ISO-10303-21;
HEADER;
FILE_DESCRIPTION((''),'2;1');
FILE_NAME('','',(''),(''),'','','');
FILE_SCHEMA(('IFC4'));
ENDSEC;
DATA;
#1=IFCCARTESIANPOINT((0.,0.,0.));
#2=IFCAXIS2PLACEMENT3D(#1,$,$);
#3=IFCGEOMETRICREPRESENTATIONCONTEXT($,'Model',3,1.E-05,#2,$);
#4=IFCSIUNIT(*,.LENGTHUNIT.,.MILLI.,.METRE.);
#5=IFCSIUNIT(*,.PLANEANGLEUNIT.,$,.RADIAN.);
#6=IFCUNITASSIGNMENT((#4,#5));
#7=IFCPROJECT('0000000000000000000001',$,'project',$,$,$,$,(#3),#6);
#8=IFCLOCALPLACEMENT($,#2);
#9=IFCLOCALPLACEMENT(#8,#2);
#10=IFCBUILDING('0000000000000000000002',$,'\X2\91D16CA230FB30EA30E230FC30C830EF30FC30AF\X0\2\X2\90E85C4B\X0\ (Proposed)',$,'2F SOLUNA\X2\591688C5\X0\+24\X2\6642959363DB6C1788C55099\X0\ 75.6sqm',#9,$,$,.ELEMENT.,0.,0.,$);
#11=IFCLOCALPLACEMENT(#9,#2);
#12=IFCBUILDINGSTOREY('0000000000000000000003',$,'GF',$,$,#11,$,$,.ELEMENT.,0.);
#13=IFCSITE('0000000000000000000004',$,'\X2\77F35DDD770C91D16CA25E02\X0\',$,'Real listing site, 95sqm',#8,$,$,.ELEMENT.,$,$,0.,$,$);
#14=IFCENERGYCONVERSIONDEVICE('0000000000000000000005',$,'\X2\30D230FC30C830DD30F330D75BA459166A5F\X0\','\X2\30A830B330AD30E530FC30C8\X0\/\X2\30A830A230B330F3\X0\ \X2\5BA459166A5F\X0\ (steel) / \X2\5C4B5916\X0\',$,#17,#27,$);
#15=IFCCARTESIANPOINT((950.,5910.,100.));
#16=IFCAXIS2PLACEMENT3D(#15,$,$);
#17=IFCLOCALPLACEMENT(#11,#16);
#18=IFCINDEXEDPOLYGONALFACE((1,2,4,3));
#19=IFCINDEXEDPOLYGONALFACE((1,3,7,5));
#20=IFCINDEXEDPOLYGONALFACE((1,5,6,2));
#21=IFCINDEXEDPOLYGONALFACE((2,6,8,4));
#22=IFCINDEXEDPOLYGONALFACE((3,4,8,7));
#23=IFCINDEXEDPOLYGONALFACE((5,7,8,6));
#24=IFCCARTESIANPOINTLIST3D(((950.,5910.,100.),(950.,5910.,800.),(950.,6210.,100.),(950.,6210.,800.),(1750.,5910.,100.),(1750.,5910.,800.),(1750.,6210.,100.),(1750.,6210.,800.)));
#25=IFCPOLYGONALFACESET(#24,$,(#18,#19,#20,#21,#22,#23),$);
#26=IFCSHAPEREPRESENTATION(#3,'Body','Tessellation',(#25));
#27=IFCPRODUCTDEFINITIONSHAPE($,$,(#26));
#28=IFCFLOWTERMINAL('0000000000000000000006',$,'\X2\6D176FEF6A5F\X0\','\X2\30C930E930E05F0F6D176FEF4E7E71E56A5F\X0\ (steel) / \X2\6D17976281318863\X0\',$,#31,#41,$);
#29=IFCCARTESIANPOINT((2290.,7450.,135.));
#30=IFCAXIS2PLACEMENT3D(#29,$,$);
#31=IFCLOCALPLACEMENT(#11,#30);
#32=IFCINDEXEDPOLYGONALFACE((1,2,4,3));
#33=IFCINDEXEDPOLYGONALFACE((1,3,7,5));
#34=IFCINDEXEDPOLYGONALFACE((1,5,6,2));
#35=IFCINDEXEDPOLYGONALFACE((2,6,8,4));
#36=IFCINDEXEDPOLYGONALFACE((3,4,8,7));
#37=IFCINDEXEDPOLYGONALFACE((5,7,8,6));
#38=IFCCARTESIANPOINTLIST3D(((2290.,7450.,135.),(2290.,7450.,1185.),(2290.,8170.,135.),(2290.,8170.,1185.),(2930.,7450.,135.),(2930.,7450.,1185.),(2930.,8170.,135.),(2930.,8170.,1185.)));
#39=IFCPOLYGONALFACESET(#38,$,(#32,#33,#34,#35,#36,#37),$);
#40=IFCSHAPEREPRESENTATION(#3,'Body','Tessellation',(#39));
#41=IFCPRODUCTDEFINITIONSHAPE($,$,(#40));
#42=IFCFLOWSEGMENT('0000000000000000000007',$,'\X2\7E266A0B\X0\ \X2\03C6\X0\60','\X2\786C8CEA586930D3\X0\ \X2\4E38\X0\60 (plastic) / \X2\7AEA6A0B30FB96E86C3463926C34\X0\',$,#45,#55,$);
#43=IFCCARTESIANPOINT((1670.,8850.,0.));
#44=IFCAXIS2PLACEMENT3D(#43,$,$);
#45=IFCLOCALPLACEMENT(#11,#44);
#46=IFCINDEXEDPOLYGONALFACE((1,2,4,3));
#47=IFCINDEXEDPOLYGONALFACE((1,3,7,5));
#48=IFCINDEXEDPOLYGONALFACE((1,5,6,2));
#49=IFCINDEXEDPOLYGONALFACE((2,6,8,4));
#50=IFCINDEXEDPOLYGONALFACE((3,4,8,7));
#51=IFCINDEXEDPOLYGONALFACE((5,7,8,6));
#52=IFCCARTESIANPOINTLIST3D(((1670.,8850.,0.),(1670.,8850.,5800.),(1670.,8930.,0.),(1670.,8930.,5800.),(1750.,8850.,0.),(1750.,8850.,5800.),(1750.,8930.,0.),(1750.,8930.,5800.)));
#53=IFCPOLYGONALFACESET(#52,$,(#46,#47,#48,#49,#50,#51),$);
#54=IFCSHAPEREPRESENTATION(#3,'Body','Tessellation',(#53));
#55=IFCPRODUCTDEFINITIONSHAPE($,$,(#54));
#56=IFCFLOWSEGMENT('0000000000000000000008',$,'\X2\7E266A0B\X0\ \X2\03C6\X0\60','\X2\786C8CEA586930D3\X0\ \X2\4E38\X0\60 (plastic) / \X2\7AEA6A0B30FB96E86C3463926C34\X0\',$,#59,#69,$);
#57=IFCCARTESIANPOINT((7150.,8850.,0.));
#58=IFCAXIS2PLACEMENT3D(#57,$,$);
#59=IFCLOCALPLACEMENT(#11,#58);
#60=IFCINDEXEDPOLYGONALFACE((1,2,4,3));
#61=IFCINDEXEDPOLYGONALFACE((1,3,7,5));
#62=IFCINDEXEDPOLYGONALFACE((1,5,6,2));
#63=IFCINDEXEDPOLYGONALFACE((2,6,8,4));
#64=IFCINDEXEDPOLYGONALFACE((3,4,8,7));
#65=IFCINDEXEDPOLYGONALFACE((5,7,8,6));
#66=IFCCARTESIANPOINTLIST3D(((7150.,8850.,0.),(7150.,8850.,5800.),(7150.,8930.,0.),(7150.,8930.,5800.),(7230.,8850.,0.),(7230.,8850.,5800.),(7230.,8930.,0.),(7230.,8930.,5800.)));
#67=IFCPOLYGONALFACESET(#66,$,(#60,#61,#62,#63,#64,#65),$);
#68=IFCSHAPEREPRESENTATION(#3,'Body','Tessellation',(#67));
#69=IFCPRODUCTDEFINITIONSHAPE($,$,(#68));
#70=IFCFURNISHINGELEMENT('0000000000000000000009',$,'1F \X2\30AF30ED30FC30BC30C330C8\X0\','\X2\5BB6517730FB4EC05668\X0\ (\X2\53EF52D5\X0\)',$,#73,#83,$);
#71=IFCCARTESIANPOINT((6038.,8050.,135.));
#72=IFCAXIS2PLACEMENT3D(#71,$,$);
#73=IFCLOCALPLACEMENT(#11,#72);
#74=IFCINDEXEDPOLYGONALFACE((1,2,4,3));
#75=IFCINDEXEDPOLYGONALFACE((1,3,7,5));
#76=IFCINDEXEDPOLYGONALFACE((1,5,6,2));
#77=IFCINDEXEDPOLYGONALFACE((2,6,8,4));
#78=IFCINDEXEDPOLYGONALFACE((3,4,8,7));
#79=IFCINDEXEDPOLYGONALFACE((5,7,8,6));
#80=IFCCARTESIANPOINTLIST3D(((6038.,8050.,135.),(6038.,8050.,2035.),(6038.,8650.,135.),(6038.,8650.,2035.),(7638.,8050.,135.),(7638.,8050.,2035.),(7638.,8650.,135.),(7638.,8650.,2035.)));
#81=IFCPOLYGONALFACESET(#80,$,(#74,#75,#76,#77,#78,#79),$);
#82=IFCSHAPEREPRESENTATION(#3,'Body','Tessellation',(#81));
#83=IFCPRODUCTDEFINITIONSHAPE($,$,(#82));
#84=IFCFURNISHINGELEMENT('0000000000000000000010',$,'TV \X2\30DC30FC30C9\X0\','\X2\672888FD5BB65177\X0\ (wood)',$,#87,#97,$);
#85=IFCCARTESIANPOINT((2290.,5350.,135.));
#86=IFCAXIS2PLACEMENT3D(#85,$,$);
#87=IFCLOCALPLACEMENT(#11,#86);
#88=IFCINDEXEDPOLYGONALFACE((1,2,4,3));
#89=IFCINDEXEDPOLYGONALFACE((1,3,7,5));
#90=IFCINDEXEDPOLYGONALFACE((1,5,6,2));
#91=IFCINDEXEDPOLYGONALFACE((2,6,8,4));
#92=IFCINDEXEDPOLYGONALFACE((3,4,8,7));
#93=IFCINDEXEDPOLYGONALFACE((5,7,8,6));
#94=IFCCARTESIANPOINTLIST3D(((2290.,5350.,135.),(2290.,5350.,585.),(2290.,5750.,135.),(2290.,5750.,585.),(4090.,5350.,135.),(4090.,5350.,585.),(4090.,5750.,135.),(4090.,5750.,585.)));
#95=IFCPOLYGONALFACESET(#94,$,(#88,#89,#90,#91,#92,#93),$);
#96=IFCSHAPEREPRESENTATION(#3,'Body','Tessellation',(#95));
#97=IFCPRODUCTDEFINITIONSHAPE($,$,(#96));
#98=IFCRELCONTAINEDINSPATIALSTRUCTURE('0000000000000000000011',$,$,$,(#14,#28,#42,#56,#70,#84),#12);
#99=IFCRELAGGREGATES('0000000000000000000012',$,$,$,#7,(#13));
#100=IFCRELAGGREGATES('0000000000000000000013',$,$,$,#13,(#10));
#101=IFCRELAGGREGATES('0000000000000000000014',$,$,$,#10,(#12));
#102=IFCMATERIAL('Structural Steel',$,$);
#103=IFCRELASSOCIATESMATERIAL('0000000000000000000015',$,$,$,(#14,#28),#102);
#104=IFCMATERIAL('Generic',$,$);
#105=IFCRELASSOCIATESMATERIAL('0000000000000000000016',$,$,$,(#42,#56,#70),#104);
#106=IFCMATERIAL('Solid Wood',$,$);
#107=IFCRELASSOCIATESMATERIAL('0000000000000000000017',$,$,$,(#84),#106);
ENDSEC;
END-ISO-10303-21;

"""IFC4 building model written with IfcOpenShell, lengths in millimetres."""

from ifc_helpers import new_model, si_unit, frame, frame_2d, origin, place, context, project, spatial, rectangle, extrude, material, element, save


model = new_model("IFC4")

# Units and contexts
model_context = context("Model", 3, precision=1e-05, world=origin())
ifc_project = project(units=[si_unit("LENGTHUNIT", "METRE", prefix="MILLI"), si_unit("PLANEANGLEUNIT", "RADIAN")], contexts=[model_context])

# Site, building, storey
site_placement = place(None, origin())
site = spatial("IfcSite", under=ifc_project, at=site_placement, Name="石川県金沢市", ObjectType="Real listing site, 95sqm", CompositionType="ELEMENT", RefElevation=0.0)
building_placement = place(site_placement, origin())
building = spatial("IfcBuilding", under=site, at=building_placement, Name="金沢・リモートワーク2部屋 (Proposed)", ObjectType="2F SOLUNA外装+24時間換気装備 75.6sqm", CompositionType="ELEMENT", ElevationOfRefHeight=0.0, ElevationOfTerrain=0.0)
storey_placement = place(building_placement, origin())
storey = spatial("IfcBuildingStorey", under=building, at=storey_placement, Name="GF", CompositionType="ELEMENT", Elevation=0.0)

# Shared definitions
ifc_material_1 = material(Name="Solid Wood")

# Shared definitions
ifc_material_2 = material(Name="Generic")

# Shared definitions
ifc_material_3 = material(Name="Structural Steel")

# Energy conversion device
energy_conversion_device_placement = place(storey_placement, frame((950.0, 5910.0, 100.0)))
element("IfcEnergyConversionDevice", 1, at=energy_conversion_device_placement, inside=storey, material=ifc_material_3, Name="ヒートポンプ室外機", Description="エコキュート/エアコン 室外機 (steel) / 屋外", context=model_context, shape_type="SweptSolid", body=[
    extrude(rectangle(XDim=800.0, YDim=300.0, at=frame_2d((400.0, 150.0))), frame((950.0, 5910.0, 100.0)), (0.0, 0.0, 1.0), 700.0),
])

# Flow terminal
flow_terminal_placement = place(storey_placement, frame((2290.0, 7450.0, 135.0)))
element("IfcFlowTerminal", 2, at=flow_terminal_placement, inside=storey, material=ifc_material_3, Name="洗濯機", Description="ドラム式洗濯乾燥機 (steel) / 洗面脱衣", context=model_context, shape_type="SweptSolid", body=[
    extrude(rectangle(XDim=640.0, YDim=720.0, at=frame_2d((320.0, 360.0))), frame((2290.0, 7450.0, 135.0)), (0.0, 0.0, 1.0), 1050.0),
])

# Flow segments
flow_segment_1_placement = place(storey_placement, frame((1670.0, 8850.0, 0.0)))
element("IfcFlowSegment", 3, at=flow_segment_1_placement, inside=storey, material=ifc_material_2, Name="縦樋 φ60", Description="硬質塩ビ 丸60 (plastic) / 竪樋・雨水排水", context=model_context, shape_type="SweptSolid", body=[
    extrude(rectangle(XDim=80.0, YDim=80.0, at=frame_2d((40.0, 40.0))), frame((1670.0, 8850.0, 0.0)), (0.0, 0.0, 1.0), 5800.0),
])
flow_segment_2_placement = place(storey_placement, frame((7150.0, 8850.0, 0.0)))
element("IfcFlowSegment", 4, at=flow_segment_2_placement, inside=storey, material=ifc_material_2, Name="縦樋 φ60", Description="硬質塩ビ 丸60 (plastic) / 竪樋・雨水排水", context=model_context, shape_type="SweptSolid", body=[
    extrude(rectangle(XDim=80.0, YDim=80.0, at=frame_2d((40.0, 40.0))), frame((7150.0, 8850.0, 0.0)), (0.0, 0.0, 1.0), 5800.0),
])

# Furnishing elements
furnishing_1_placement = place(storey_placement, frame((6038.0, 8050.0, 135.0)))
element("IfcFurnishingElement", 5, at=furnishing_1_placement, inside=storey, material=ifc_material_2, Name="1F クローゼット", Description="家具・什器 (可動)", context=model_context, shape_type="SweptSolid", body=[
    extrude(rectangle(XDim=1600.0, YDim=600.0, at=frame_2d((800.0, 300.0))), frame((6038.0, 8050.0, 135.0)), (0.0, 0.0, 1.0), 1900.0),
])
furnishing_2_placement = place(storey_placement, frame((2290.0, 5350.0, 135.0)))
element("IfcFurnishingElement", 6, at=furnishing_2_placement, inside=storey, material=ifc_material_1, Name="TV ボード", Description="木製家具 (wood)", context=model_context, shape_type="SweptSolid", body=[
    extrude(rectangle(XDim=1800.0, YDim=400.0, at=frame_2d((900.0, 200.0))), frame((2290.0, 5350.0, 135.0)), (0.0, 0.0, 1.0), 450.0),
])

save(model, "model.ifc")
